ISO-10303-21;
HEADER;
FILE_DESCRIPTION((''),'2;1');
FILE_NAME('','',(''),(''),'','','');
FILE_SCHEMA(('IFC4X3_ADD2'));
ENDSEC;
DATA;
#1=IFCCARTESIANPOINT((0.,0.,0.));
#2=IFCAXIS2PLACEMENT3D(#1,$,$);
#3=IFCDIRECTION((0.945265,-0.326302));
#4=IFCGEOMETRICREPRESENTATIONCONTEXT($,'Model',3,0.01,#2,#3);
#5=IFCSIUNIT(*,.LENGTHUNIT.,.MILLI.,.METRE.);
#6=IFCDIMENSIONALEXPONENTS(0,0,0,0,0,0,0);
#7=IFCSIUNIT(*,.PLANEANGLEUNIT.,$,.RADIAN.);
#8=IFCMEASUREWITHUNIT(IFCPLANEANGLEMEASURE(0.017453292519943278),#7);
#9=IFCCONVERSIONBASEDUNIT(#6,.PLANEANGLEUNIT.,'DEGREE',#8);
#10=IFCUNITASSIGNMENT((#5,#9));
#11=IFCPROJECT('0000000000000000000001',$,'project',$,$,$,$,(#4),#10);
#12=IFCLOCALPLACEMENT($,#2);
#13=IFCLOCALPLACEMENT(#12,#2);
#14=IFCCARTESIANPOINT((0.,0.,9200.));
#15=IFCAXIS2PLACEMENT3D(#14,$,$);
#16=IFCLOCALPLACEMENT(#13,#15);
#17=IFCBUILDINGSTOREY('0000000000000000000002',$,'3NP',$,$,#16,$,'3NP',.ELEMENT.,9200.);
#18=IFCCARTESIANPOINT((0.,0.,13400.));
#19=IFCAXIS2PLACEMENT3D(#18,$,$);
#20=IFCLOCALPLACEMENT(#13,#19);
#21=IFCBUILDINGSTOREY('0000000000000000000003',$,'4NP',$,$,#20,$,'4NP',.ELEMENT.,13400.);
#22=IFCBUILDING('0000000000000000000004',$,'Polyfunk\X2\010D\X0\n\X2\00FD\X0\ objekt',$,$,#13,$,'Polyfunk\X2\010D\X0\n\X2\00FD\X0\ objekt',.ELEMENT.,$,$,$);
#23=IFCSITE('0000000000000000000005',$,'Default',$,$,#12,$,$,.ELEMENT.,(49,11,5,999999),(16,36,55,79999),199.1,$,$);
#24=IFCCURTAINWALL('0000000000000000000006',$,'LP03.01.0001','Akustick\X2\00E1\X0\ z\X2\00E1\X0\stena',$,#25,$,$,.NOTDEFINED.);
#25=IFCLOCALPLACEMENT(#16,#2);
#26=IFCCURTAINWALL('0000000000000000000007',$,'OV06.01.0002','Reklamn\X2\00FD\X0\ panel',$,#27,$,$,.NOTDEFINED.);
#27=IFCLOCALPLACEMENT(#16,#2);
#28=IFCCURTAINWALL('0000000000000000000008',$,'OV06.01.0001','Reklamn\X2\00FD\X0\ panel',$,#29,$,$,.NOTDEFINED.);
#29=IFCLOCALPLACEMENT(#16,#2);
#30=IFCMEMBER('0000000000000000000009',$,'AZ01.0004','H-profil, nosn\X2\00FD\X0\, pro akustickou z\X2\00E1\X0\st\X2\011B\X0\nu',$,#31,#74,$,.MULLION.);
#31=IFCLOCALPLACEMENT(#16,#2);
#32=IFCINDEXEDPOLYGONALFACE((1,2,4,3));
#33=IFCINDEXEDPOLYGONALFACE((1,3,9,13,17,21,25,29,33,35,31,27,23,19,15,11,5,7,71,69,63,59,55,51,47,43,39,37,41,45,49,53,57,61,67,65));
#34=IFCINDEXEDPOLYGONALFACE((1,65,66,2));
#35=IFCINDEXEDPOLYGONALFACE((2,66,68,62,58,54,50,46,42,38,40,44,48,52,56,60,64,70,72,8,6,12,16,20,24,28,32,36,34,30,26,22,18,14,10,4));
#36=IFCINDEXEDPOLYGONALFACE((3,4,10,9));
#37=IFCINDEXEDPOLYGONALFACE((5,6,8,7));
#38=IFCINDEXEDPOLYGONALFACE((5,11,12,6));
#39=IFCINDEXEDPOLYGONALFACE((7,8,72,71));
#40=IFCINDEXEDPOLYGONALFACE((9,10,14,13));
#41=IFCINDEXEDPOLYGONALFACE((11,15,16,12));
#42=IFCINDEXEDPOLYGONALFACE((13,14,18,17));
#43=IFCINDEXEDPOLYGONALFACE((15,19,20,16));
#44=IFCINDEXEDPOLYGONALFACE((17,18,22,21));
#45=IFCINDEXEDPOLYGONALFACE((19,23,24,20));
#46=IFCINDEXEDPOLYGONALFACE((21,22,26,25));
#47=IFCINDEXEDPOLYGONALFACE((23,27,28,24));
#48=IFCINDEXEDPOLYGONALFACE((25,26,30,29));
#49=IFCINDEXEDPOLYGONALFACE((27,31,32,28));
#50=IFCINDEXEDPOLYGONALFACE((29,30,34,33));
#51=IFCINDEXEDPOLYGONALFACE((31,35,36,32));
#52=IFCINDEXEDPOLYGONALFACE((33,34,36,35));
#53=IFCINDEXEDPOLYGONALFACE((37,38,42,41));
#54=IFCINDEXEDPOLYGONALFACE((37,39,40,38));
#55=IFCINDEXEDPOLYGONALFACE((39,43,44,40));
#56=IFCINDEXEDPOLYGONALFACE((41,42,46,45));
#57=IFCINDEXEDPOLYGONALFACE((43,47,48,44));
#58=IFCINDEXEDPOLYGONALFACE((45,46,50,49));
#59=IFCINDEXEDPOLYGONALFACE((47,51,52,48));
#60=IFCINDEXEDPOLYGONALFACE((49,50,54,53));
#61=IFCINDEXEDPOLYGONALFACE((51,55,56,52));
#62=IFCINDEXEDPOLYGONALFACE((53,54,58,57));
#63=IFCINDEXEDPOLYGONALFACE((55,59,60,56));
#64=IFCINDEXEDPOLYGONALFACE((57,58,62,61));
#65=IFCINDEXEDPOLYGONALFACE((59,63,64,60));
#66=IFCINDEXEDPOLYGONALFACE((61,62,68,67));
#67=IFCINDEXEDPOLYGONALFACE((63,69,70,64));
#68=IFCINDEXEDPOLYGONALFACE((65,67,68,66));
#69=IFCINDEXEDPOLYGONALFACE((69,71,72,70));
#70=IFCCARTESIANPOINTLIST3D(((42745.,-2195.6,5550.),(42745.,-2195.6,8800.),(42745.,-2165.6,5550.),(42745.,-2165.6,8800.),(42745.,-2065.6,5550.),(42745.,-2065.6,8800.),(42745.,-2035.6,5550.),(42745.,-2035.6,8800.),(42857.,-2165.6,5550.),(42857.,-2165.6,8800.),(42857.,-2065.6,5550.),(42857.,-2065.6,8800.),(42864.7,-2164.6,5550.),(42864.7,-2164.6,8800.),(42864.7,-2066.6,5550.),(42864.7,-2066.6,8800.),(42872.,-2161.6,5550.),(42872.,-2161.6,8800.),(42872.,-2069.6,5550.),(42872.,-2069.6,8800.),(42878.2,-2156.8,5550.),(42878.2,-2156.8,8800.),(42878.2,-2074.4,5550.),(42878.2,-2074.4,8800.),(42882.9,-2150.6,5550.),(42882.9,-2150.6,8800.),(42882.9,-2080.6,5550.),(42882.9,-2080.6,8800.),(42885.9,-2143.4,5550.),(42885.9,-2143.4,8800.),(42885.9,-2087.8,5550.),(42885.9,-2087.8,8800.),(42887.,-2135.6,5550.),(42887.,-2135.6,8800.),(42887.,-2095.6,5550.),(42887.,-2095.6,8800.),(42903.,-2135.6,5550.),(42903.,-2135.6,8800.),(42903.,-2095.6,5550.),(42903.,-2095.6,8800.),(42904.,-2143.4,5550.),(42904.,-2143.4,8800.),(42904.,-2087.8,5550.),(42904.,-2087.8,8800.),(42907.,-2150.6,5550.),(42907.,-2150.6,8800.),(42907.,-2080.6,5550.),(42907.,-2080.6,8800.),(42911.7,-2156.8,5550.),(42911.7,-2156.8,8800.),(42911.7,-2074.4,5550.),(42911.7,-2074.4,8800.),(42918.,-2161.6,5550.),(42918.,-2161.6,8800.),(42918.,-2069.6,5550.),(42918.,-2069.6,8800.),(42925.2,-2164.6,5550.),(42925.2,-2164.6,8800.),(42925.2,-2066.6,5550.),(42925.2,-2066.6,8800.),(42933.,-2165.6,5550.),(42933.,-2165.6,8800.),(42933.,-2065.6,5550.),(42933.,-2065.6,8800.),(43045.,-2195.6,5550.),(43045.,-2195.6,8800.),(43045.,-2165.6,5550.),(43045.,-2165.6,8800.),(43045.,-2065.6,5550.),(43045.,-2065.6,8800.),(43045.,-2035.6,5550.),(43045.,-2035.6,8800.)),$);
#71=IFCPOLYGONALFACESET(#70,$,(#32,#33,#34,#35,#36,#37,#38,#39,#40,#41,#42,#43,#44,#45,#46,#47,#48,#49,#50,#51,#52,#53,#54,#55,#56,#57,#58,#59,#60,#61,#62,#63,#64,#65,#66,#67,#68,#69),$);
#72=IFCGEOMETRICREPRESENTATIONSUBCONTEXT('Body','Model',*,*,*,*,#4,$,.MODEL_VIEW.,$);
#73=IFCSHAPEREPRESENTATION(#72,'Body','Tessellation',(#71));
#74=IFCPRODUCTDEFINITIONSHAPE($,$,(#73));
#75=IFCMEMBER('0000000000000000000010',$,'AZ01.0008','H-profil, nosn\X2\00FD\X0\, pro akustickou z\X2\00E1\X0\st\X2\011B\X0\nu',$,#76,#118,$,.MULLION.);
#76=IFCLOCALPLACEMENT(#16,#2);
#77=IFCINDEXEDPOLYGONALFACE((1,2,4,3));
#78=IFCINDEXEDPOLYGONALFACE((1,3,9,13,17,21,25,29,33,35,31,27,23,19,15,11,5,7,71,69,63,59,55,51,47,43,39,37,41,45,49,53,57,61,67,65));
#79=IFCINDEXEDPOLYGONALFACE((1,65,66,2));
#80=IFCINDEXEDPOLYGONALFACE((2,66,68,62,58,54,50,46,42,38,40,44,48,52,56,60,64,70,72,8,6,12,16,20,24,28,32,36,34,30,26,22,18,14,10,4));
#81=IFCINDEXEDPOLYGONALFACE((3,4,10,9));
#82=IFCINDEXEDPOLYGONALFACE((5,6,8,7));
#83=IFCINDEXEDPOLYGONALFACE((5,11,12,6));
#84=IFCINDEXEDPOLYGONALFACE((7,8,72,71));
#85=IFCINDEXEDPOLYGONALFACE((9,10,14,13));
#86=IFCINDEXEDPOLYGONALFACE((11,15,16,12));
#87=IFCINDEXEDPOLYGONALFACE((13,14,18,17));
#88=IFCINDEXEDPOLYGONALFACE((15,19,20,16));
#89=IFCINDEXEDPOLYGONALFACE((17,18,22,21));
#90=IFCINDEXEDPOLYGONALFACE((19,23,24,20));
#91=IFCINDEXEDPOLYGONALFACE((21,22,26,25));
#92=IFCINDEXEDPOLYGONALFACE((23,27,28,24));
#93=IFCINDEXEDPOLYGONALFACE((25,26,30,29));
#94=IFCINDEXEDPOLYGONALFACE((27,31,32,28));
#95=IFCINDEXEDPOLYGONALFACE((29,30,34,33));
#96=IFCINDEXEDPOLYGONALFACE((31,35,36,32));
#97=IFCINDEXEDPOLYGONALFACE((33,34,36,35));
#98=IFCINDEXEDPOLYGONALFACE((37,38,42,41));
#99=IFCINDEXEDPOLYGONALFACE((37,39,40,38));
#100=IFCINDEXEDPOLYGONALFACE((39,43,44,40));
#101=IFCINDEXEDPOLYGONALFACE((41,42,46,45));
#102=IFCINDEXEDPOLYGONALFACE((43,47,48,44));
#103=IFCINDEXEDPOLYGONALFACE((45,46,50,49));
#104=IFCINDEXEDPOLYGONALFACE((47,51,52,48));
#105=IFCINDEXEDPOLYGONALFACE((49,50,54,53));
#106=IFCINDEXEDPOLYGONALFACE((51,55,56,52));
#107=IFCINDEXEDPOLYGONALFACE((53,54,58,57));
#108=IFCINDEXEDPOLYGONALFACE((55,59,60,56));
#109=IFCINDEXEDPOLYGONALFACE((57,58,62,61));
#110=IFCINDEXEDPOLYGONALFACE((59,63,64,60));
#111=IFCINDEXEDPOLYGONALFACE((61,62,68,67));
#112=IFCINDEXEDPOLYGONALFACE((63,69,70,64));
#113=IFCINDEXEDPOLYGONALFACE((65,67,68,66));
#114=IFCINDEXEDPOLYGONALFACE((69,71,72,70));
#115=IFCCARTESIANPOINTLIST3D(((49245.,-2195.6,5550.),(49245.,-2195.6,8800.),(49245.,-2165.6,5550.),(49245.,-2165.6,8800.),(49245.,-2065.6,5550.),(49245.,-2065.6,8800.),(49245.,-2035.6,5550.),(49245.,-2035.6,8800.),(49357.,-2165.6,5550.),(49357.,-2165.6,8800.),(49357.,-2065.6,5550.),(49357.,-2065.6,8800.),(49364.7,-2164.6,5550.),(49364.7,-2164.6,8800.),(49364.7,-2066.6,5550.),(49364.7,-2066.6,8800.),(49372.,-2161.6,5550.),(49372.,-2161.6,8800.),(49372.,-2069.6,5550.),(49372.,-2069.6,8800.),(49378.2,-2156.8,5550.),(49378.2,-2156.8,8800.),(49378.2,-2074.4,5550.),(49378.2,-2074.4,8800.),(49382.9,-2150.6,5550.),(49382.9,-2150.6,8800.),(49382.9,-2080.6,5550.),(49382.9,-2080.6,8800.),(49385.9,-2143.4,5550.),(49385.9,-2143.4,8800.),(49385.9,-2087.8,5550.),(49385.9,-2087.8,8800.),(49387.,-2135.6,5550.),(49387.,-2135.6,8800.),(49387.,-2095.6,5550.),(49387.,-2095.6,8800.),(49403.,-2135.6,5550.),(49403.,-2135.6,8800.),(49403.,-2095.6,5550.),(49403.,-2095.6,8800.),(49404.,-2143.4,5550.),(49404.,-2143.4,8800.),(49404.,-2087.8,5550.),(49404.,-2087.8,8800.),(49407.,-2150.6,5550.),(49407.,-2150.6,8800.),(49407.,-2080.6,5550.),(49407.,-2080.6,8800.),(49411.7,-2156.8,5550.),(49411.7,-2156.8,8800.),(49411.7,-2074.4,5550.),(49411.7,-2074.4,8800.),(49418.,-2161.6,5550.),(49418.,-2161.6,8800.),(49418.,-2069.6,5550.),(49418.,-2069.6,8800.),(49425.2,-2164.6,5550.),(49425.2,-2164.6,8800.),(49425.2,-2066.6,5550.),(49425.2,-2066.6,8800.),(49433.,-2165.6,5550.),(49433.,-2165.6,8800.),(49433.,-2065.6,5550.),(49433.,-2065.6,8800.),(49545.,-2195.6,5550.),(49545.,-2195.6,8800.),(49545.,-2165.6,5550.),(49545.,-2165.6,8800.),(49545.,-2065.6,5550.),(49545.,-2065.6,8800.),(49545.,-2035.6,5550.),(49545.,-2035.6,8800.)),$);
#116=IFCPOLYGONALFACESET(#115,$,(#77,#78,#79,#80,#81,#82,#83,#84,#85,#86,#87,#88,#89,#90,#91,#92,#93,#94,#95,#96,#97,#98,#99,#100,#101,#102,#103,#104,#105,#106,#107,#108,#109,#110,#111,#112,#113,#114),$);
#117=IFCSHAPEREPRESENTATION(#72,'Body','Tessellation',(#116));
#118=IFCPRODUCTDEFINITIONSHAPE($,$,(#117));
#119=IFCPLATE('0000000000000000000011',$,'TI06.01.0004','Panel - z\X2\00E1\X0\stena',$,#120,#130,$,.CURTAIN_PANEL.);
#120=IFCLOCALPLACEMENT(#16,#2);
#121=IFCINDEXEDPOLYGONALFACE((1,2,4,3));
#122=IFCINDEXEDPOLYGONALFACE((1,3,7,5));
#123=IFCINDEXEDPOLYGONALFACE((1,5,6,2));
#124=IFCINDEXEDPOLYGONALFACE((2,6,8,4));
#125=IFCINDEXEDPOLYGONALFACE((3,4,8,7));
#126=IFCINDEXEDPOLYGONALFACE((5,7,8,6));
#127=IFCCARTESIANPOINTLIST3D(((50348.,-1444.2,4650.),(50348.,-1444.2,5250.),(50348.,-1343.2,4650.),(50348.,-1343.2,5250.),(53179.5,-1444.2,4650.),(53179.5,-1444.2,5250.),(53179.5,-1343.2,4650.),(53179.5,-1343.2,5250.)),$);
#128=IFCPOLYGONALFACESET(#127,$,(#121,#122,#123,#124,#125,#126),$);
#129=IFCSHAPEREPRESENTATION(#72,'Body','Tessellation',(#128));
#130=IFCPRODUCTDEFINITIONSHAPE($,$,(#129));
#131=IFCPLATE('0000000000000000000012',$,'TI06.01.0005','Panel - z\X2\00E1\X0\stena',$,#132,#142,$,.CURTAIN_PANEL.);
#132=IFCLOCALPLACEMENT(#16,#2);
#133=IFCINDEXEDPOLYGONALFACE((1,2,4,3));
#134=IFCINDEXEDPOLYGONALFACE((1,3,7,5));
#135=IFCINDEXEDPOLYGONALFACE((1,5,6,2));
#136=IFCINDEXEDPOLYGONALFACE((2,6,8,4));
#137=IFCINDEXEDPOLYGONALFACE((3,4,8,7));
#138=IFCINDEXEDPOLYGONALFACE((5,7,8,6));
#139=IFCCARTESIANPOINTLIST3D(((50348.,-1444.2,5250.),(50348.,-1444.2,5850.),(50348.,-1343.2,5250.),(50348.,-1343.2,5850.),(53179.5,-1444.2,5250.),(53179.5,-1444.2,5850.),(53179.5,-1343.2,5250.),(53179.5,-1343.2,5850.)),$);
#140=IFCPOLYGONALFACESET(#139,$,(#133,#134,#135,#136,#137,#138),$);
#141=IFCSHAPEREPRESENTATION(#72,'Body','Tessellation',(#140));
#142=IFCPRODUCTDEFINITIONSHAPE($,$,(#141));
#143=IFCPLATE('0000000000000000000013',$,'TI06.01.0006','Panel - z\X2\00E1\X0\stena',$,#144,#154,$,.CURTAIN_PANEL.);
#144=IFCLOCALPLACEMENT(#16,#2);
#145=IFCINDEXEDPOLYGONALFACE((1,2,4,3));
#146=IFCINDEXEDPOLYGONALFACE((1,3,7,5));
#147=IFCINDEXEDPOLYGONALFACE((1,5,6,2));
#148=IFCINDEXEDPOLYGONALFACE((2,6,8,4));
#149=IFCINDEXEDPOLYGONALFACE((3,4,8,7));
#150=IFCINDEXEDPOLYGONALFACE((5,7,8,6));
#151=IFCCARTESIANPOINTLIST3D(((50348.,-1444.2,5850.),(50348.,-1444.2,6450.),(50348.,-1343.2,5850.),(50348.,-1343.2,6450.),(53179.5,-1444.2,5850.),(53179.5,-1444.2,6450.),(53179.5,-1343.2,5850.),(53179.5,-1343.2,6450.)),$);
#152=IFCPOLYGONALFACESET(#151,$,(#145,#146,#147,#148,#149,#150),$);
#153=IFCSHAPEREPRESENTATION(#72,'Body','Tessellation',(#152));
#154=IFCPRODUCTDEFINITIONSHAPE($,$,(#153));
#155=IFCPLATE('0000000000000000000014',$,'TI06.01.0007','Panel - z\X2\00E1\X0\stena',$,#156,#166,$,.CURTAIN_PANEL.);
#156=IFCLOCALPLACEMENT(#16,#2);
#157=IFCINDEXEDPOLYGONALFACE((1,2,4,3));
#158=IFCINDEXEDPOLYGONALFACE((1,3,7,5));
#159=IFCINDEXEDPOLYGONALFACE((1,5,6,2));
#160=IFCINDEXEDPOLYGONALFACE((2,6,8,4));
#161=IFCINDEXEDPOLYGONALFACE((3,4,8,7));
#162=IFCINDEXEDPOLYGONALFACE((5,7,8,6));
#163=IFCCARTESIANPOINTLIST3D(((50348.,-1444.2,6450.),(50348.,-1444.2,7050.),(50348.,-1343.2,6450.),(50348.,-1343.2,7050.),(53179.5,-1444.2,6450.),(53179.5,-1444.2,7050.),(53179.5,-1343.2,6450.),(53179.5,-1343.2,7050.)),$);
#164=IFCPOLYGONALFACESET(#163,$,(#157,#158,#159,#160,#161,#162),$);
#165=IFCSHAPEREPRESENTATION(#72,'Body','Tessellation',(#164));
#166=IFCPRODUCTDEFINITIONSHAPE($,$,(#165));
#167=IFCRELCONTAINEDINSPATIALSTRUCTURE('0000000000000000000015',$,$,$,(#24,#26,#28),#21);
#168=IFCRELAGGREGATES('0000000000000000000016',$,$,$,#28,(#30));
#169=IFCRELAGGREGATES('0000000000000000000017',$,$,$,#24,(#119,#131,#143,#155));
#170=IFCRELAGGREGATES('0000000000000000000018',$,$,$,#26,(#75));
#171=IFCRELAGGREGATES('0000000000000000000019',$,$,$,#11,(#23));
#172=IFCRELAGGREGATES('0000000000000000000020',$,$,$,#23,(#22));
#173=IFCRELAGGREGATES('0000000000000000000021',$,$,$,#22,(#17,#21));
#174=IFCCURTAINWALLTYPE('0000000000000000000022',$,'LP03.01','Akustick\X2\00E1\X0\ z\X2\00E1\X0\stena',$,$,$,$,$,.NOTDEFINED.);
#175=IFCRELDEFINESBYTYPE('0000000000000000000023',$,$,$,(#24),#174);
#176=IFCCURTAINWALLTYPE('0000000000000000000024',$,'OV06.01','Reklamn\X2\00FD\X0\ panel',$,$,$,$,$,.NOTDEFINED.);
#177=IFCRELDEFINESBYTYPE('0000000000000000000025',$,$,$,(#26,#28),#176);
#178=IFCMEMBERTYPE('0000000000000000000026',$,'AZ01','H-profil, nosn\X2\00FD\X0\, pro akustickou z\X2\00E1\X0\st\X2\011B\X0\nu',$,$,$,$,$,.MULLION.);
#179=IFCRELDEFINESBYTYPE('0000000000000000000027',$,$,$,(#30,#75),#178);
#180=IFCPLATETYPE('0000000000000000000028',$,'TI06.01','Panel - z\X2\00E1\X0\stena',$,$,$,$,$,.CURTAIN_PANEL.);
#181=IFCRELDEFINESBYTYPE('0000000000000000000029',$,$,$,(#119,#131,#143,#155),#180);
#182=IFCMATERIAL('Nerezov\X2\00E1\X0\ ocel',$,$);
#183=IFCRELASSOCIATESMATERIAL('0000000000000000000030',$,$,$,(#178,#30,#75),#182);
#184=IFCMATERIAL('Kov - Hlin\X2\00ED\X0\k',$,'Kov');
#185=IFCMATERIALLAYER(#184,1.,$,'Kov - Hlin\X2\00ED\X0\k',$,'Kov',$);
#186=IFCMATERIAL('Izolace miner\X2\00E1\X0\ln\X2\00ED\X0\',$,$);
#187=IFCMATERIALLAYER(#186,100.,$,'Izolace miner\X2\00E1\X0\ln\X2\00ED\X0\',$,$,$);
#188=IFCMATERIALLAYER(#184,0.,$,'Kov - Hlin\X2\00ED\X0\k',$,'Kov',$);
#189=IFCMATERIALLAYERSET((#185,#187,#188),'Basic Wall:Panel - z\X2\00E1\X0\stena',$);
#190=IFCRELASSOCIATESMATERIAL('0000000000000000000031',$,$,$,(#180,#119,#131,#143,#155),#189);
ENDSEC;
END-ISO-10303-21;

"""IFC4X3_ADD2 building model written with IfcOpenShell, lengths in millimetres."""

from ifc_helpers import new_model, entity, si_unit, converted_unit, direction, frame, frame_2d, origin, place, context, subcontext, project, spatial, polyline, circle_curve, parameter, trimmed, segment, composite_curve, rectangle, outline, extrude, source, transform, mapped, material, layer, layer_set, layer_usage, material_profile, profile_set, profile_usage, type_object, element, aggregate, save


model = new_model("IFC4X3_ADD2")

# Units and contexts
model_context = context("Model", 3, precision=0.01, world=origin(), true_north=direction((0.945265, -0.326302)))
body_context = subcontext(model_context, "Body", "Model", "MODEL_VIEW")
ifc_project = project(units=[si_unit("LENGTHUNIT", "METRE", prefix="MILLI"), converted_unit("PLANEANGLEUNIT", "DEGREE", entity("IfcPlaneAngleMeasure", 0.017453292519943278), si_unit("PLANEANGLEUNIT", "RADIAN"), dimensions=[0, 0, 0, 0, 0, 0, 0])], contexts=[model_context])

# Site, building, storey
site_placement = place(None, origin())
site = spatial("IfcSite", under=ifc_project, at=site_placement, Name="Default", CompositionType="ELEMENT", RefLatitude=(49, 11, 5, 999999), RefLongitude=(16, 36, 55, 79999), RefElevation=199.1)
building_placement = place(site_placement, origin())
building = spatial("IfcBuilding", under=site, at=building_placement, Name="Polyfunkčný objekt", LongName="Polyfunkčný objekt", CompositionType="ELEMENT")
storey_1_placement = place(building_placement, frame((0.0, 0.0, 9200.0)))
storey_1 = spatial("IfcBuildingStorey", under=building, at=storey_1_placement, Name="3NP", LongName="3NP", CompositionType="ELEMENT", Elevation=9200.0)

# Shared definitions
storey_2_placement = place(building_placement, frame((0.0, 0.0, 13400.0)))
storey_2 = spatial("IfcBuildingStorey", under=building, at=storey_2_placement, Name="4NP", LongName="4NP", CompositionType="ELEMENT", Elevation=13400.0)

# Curtain wall
curtain_wall_type_1 = type_object("IfcCurtainWallType", Name="LP03.01", Description="Akustická zástena", PredefinedType="NOTDEFINED")
curtain_wall_1_placement = place(storey_2_placement, frame((0.0, 0.0, -13400.0)))
curtain_wall_1 = element("IfcCurtainWall", 1, at=curtain_wall_1_placement, inside=storey_2, type_object=curtain_wall_type_1, Name="LP03.01.0001", Description="Akustická zástena", PredefinedType="NOTDEFINED")
ifc_material_1 = material(Name="Nerezová ocel")
ifc_material_profile_1 = material_profile(ifc_material_1, outline(composite_curve([segment(polyline([(50.0, -150.0), (80.0, -150.0)]), True, "CONTINUOUS"), segment(polyline([(80.0, -150.0), (80.0, 150.0)]), True, "CONTINUOUS"), segment(polyline([(80.0, 150.0), (50.0, 150.0)]), True, "CONTINUOUS"), segment(polyline([(50.0, 150.0), (50.0, 38.0)]), True, "CONTINUOUS"), segment(trimmed(circle_curve(frame_2d((20.0, 38.0), x_axis=(0.0, 1.0)), 30.0), [parameter(180.0)], [parameter(270.0)], True, "PARAMETER"), False, "CONTINUOUS"), segment(polyline([(20.0, 8.0), (-20.0, 8.0)]), True, "CONTINUOUS"), segment(trimmed(circle_curve(frame_2d((-20.0, 38.0), x_axis=(0.0, 1.0)), 30.0), [parameter(90.0)], [parameter(180.0)], True, "PARAMETER"), False, "CONTINUOUS"), segment(polyline([(-50.0, 38.0), (-50.0, 150.0)]), True, "CONTINUOUS"), segment(polyline([(-50.0, 150.0), (-80.0, 150.0)]), True, "CONTINUOUS"), segment(polyline([(-80.0, 150.0), (-80.0, -150.0)]), True, "CONTINUOUS"), segment(polyline([(-80.0, -150.0), (-50.0, -150.0)]), True, "CONTINUOUS"), segment(polyline([(-50.0, -150.0), (-50.0, -38.0)]), True, "CONTINUOUS"), segment(trimmed(circle_curve(frame_2d((-20.0, -38.0), x_axis=(0.0, 1.0)), 30.0), [parameter(0.0)], [parameter(90.0)], True, "PARAMETER"), False, "CONTINUOUS"), segment(polyline([(-20.0, -8.0), (20.0, -8.0)]), True, "CONTINUOUS"), segment(trimmed(circle_curve(frame_2d((20.0, -38.0), x_axis=(0.0, 1.0)), 30.0), [parameter(270.0)], [parameter(0.0)], True, "PARAMETER"), False, "CONTINUOUS"), segment(polyline([(50.0, -38.0), (50.0, -150.0)]), True, "CONTINUOUS")], self_intersect=False)), Name="Profil zástena")
ifc_profile_set_1 = profile_set([ifc_material_profile_1], Name="Profil zástena")
ifc_profile_usage_1 = profile_usage(ifc_profile_set_1)
member_type_1 = type_object("IfcMemberType", Name="AZ01", Description="H-profil, nosný, pro akustickou zástěnu", PredefinedType="MULLION", material=ifc_profile_set_1)

# Curtain walls
curtain_wall_type_2 = type_object("IfcCurtainWallType", Name="OV06.01", Description="Reklamný panel", PredefinedType="NOTDEFINED")
curtain_wall_2_placement = place(storey_2_placement, frame((0.0, 0.0, -13400.0)))
curtain_wall_2 = element("IfcCurtainWall", 2, at=curtain_wall_2_placement, inside=storey_2, type_object=curtain_wall_type_2, Name="OV06.01.0002", Description="Reklamný panel", PredefinedType="NOTDEFINED")
curtain_wall_3_placement = place(storey_2_placement, frame((0.0, 0.0, -13400.0)))
curtain_wall_3 = element("IfcCurtainWall", 3, at=curtain_wall_3_placement, inside=storey_2, type_object=curtain_wall_type_2, Name="OV06.01.0001", Description="Reklamný panel", PredefinedType="NOTDEFINED")

# Members
shared_shape_1 = source(origin(), body_context, "Body", "SweptSolid", [
    extrude(outline(composite_curve([segment(polyline([(-150.0, -50.0), (-150.0, -80.0)]), True, "CONTINUOUS"), segment(polyline([(-150.0, -80.0), (150.0, -80.0)]), True, "CONTINUOUS"), segment(polyline([(150.0, -80.0), (150.0, -50.0)]), True, "CONTINUOUS"), segment(polyline([(150.0, -50.0), (38.0, -50.0)]), True, "CONTINUOUS"), segment(trimmed(circle_curve(frame_2d((38.0, -20.0), x_axis=(1.0, 0.0)), 30.0), [parameter(180.0)], [parameter(270.0)], True, "PARAMETER"), False, "CONTINUOUS"), segment(polyline([(8.0, -20.0), (8.0, 20.0)]), True, "CONTINUOUS"), segment(trimmed(circle_curve(frame_2d((38.0, 20.0), x_axis=(1.0, 0.0)), 30.0), [parameter(90.0)], [parameter(180.0)], True, "PARAMETER"), False, "CONTINUOUS"), segment(polyline([(38.0, 50.0), (150.0, 50.0)]), True, "CONTINUOUS"), segment(polyline([(150.0, 50.0), (150.0, 80.0)]), True, "CONTINUOUS"), segment(polyline([(150.0, 80.0), (-150.0, 80.0)]), True, "CONTINUOUS"), segment(polyline([(-150.0, 80.0), (-150.0, 50.0)]), True, "CONTINUOUS"), segment(polyline([(-150.0, 50.0), (-38.0, 50.0)]), True, "CONTINUOUS"), segment(trimmed(circle_curve(frame_2d((-38.0, 20.0), x_axis=(1.0, 0.0)), 30.0), [parameter(0.0)], [parameter(90.0)], True, "PARAMETER"), False, "CONTINUOUS"), segment(polyline([(-8.0, 20.0), (-8.0, -20.0)]), True, "CONTINUOUS"), segment(trimmed(circle_curve(frame_2d((-38.0, -20.0), x_axis=(1.0, 0.0)), 30.0), [parameter(270.0)], [parameter(0.0)], True, "PARAMETER"), False, "CONTINUOUS"), segment(polyline([(-38.0, -50.0), (-150.0, -50.0)]), True, "CONTINUOUS")], self_intersect=False)), frame((-150.0, 0.0, -3250.0), z_axis=(0.0, 0.0, -1.0), x_axis=(1.0, 0.0, 0.0)), (0.0, 0.0, -1.0), 3250.0),
])
member_1_placement = place(curtain_wall_3_placement, frame((43045.0, -2115.6, 14750.0), z_axis=(0.0, 0.0, -1.0), x_axis=(1.0, 0.0, 0.0)))
member_1 = element("IfcMember", 4, at=member_1_placement, type_object=member_type_1, material=ifc_profile_usage_1, Name="AZ01.0004", Description="H-profil, nosný, pro akustickou zástěnu", PredefinedType="MULLION", context=body_context, shape_type="MappedRepresentation", body=[
    mapped(shared_shape_1, transform((0.0, 0.0, 0.0), scale=1.0)),
])
aggregate(curtain_wall_3, [member_1])
member_2_placement = place(curtain_wall_2_placement, frame((49545.0, -2115.6, 14750.0), z_axis=(0.0, 0.0, -1.0), x_axis=(1.0, 0.0, 0.0)))
member_2 = element("IfcMember", 5, at=member_2_placement, type_object=member_type_1, material=ifc_profile_usage_1, Name="AZ01.0008", Description="H-profil, nosný, pro akustickou zástěnu", PredefinedType="MULLION", context=body_context, shape_type="MappedRepresentation", body=[
    mapped(shared_shape_1, transform((0.0, 0.0, 0.0), scale=1.0)),
])

# Plates
ifc_material_2 = material(Name="Kov - Hliník", Category="Kov")
ifc_layer_1 = layer(ifc_material_2, 1.0, Name="Kov - Hliník", Category="Kov")
ifc_material_3 = material(Name="Izolace minerální")
ifc_layer_2 = layer(ifc_material_3, 100.0, Name="Izolace minerální")
ifc_layer_3 = layer(ifc_material_2, 0.0, Name="Kov - Hliník", Category="Kov")
ifc_layer_set_1 = layer_set([ifc_layer_1, ifc_layer_2, ifc_layer_3], Name="Basic Wall:Panel - zástena")
ifc_layer_usage_1 = layer_usage(ifc_layer_set_1, "AXIS2", "POSITIVE", -50.5)
plate_type = type_object("IfcPlateType", Name="TI06.01", Description="Panel - zástena", PredefinedType="CURTAIN_PANEL", material=ifc_layer_set_1)
plate_1_placement = place(storey_2_placement, frame((50348.0, -1393.7, 450.0)))
plate_1 = element("IfcPlate", 6, at=plate_1_placement, type_object=plate_type, material=ifc_layer_usage_1, Name="TI06.01.0004", Description="Panel - zástena", PredefinedType="CURTAIN_PANEL", context=body_context, shape_type="SweptSolid", body=[
    extrude(rectangle(XDim=101.0, YDim=2831.5, at=frame_2d((0.0, 0.0), x_axis=(1.0, 0.0))), frame((1415.8, 0.0, 0.0), z_axis=(0.0, 0.0, 1.0), x_axis=(0.0, 1.0, 0.0)), (0.0, 0.0, 1.0), 600.0),
])
ifc_layer_usage_2 = layer_usage(ifc_layer_set_1, "AXIS2", "POSITIVE", -50.5)
plate_2_placement = place(storey_2_placement, frame((50348.0, -1393.7, 1050.0)))
plate_2 = element("IfcPlate", 7, at=plate_2_placement, type_object=plate_type, material=ifc_layer_usage_2, Name="TI06.01.0005", Description="Panel - zástena", PredefinedType="CURTAIN_PANEL", context=body_context, shape_type="SweptSolid", body=[
    extrude(rectangle(XDim=101.0, YDim=2831.5, at=frame_2d((0.0, 0.0), x_axis=(1.0, 0.0))), frame((1415.8, 0.0, 0.0), z_axis=(0.0, 0.0, 1.0), x_axis=(0.0, 1.0, 0.0)), (0.0, 0.0, 1.0), 600.0),
])
ifc_layer_usage_3 = layer_usage(ifc_layer_set_1, "AXIS2", "POSITIVE", -50.5)
plate_3_placement = place(storey_2_placement, frame((50348.0, -1393.7, 1650.0)))
plate_3 = element("IfcPlate", 8, at=plate_3_placement, type_object=plate_type, material=ifc_layer_usage_3, Name="TI06.01.0006", Description="Panel - zástena", PredefinedType="CURTAIN_PANEL", context=body_context, shape_type="SweptSolid", body=[
    extrude(rectangle(XDim=101.0, YDim=2831.5, at=frame_2d((0.0, 0.0), x_axis=(1.0, 0.0))), frame((1415.8, 0.0, 0.0), z_axis=(0.0, 0.0, 1.0), x_axis=(0.0, 1.0, 0.0)), (0.0, 0.0, 1.0), 600.0),
])
ifc_layer_usage_4 = layer_usage(ifc_layer_set_1, "AXIS2", "POSITIVE", -50.5)
plate_4_placement = place(storey_2_placement, frame((50348.0, -1393.7, 2250.0)))
plate_4 = element("IfcPlate", 9, at=plate_4_placement, type_object=plate_type, material=ifc_layer_usage_4, Name="TI06.01.0007", Description="Panel - zástena", PredefinedType="CURTAIN_PANEL", context=body_context, shape_type="SweptSolid", body=[
    extrude(rectangle(XDim=101.0, YDim=2831.5, at=frame_2d((0.0, 0.0), x_axis=(1.0, 0.0))), frame((1415.8, 0.0, 0.0), z_axis=(0.0, 0.0, 1.0), x_axis=(0.0, 1.0, 0.0)), (0.0, 0.0, 1.0), 600.0),
])
aggregate(curtain_wall_1, [plate_1, plate_2, plate_3, plate_4])
aggregate(curtain_wall_2, [member_2])

save(model, "model.ifc")
